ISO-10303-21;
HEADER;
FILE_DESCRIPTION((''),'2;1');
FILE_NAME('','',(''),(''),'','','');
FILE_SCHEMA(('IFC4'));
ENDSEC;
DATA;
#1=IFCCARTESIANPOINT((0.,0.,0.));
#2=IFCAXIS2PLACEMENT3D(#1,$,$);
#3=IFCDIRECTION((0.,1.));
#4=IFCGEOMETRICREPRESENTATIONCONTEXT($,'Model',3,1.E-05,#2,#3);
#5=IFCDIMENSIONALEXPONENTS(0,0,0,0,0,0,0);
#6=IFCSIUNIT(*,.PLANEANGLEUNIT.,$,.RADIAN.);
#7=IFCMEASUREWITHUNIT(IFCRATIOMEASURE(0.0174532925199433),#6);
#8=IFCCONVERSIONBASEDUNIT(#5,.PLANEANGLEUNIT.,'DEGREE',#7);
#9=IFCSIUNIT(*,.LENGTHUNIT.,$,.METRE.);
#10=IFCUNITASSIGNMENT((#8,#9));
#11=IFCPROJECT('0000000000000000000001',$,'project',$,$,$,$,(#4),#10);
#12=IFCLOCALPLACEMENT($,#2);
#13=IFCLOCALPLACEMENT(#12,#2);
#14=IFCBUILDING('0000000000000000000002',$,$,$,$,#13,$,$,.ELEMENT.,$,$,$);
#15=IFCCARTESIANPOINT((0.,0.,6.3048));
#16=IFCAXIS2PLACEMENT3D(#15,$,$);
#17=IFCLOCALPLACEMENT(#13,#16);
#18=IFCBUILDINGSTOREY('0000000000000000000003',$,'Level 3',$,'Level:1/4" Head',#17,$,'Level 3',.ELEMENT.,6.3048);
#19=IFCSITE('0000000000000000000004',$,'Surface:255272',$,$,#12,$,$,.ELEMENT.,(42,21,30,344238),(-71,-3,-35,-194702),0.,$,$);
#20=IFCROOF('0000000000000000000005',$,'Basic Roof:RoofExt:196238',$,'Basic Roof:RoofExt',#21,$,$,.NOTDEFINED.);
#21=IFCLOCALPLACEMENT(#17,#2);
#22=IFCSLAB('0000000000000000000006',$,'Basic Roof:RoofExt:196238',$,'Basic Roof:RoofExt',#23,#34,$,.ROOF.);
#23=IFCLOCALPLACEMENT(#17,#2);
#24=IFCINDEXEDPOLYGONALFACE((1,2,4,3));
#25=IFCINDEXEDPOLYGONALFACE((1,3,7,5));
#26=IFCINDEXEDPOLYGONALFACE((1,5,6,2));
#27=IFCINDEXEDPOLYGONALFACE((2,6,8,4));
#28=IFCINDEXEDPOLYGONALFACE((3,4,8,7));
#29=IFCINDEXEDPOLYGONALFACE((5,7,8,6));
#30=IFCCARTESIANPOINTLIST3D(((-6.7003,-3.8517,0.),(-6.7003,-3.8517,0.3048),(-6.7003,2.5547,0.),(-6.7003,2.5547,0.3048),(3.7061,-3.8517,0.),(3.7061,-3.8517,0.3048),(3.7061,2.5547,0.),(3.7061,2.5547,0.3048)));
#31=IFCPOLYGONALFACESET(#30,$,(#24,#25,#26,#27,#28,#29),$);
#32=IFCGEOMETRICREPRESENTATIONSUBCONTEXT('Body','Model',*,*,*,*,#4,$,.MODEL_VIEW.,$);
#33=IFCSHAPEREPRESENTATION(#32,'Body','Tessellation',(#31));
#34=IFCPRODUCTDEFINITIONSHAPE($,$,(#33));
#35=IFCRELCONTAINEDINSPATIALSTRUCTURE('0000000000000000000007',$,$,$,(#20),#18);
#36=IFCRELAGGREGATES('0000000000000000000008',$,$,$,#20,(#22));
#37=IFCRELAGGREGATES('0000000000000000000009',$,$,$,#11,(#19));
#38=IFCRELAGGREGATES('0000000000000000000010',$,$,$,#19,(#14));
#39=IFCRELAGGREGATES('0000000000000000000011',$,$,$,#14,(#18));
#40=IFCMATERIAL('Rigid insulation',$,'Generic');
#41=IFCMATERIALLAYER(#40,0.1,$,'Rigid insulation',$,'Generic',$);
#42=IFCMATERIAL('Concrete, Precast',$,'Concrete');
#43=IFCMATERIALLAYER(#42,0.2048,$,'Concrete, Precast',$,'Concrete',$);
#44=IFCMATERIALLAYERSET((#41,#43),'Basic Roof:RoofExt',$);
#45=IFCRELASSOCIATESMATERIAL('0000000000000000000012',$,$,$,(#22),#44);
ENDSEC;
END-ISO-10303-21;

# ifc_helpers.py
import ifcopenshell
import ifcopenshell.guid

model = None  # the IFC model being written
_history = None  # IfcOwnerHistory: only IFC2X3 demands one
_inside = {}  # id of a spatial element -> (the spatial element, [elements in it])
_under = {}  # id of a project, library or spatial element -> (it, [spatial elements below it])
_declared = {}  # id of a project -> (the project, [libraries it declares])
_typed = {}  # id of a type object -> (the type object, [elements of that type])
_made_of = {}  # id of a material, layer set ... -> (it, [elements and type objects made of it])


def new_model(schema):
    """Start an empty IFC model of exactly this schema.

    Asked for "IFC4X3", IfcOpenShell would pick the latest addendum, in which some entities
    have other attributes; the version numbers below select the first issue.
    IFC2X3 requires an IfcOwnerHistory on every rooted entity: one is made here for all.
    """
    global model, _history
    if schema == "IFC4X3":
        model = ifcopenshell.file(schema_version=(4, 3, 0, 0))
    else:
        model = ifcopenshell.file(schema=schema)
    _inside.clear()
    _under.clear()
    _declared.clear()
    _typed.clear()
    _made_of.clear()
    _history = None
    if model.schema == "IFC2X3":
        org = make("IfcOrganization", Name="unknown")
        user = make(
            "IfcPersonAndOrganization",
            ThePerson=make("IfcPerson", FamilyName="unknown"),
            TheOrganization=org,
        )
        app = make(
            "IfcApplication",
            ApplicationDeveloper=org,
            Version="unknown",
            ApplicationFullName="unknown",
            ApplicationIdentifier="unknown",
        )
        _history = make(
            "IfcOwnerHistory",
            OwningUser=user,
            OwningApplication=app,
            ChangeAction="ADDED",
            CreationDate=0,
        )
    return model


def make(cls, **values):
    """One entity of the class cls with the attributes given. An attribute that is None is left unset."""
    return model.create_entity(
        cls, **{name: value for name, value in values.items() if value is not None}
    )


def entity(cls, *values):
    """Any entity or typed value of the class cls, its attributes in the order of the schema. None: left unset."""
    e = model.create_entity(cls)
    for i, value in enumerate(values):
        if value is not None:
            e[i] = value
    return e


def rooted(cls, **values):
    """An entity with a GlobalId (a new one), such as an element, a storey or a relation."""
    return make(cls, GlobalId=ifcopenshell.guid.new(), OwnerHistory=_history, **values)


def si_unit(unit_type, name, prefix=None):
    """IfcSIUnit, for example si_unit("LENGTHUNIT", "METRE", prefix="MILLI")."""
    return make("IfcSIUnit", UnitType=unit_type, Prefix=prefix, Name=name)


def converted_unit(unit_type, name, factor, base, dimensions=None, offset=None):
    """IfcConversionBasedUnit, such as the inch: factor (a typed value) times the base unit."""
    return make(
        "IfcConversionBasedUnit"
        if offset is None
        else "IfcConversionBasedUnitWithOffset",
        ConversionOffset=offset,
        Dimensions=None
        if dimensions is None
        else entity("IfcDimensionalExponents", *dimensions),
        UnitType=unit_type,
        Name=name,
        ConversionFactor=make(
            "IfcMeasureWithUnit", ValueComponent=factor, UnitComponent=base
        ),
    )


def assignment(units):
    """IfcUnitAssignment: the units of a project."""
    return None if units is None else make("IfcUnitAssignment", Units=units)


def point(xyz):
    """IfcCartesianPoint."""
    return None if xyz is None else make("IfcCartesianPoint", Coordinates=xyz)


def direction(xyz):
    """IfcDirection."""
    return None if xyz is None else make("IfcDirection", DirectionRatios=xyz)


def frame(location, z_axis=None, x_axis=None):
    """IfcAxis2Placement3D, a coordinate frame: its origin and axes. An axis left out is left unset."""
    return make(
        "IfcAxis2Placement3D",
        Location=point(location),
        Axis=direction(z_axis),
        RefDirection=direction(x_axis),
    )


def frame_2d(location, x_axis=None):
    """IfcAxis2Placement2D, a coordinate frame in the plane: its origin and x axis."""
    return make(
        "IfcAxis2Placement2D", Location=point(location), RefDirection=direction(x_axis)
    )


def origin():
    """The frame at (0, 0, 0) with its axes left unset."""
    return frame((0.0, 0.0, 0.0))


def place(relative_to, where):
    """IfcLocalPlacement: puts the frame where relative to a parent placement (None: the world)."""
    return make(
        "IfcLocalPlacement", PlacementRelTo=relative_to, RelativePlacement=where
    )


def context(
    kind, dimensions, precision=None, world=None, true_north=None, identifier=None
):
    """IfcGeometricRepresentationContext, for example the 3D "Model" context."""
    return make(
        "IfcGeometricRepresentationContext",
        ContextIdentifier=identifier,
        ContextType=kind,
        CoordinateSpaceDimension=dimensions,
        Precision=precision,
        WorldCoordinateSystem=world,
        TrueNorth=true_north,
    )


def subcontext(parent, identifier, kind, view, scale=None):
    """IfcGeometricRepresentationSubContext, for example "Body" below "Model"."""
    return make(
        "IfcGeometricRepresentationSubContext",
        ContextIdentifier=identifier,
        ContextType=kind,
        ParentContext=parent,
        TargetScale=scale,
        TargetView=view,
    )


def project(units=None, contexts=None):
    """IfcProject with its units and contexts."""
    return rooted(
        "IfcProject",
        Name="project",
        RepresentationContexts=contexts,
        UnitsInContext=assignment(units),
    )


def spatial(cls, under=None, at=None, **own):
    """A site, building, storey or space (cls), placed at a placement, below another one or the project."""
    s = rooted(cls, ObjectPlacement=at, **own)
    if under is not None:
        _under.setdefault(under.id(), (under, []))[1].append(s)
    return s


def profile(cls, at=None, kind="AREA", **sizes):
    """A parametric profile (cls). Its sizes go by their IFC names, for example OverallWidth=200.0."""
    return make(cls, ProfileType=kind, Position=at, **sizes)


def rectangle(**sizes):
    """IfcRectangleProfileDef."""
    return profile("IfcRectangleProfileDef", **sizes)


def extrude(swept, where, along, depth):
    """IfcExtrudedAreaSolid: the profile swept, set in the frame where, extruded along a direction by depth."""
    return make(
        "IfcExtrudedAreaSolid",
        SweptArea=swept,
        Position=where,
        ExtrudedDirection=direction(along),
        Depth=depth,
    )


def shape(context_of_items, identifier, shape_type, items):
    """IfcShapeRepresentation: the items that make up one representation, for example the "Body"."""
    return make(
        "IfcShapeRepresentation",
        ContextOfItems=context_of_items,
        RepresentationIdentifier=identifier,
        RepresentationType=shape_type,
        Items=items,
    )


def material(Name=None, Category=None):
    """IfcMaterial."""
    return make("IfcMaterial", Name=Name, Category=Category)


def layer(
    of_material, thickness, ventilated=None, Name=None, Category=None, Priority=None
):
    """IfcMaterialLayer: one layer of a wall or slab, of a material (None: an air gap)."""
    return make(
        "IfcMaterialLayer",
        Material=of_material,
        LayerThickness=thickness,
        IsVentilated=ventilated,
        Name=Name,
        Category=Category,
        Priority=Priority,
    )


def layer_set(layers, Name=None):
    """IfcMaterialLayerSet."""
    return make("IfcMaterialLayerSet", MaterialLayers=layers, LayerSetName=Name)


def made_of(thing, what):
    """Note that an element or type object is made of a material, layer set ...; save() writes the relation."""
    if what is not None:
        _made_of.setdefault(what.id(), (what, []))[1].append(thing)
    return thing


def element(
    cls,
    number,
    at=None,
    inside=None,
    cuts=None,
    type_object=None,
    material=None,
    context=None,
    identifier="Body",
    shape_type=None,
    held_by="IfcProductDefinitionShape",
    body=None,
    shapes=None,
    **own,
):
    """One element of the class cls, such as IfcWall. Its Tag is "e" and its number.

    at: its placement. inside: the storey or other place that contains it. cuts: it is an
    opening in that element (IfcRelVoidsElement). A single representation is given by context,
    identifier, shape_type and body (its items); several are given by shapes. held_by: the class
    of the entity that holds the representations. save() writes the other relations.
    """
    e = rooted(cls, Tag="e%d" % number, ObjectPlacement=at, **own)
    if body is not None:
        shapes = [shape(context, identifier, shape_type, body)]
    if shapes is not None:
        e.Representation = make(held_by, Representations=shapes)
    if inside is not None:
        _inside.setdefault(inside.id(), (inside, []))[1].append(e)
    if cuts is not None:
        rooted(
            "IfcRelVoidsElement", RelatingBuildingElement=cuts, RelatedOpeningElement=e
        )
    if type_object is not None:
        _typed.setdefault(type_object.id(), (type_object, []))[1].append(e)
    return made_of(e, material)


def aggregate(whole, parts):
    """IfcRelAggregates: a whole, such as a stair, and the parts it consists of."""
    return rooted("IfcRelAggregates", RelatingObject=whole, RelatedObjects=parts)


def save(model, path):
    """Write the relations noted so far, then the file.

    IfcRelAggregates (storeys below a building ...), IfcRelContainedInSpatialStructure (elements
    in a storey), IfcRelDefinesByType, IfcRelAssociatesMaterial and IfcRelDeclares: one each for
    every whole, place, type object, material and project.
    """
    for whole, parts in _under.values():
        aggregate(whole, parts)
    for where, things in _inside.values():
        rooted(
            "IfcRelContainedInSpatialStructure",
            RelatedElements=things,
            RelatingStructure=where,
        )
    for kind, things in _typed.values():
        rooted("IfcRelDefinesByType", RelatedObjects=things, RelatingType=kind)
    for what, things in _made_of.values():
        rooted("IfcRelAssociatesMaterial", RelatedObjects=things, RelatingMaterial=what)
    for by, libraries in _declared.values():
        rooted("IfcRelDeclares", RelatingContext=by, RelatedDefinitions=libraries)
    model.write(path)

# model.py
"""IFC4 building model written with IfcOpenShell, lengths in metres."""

from ifc_helpers import new_model, entity, si_unit, converted_unit, direction, frame, frame_2d, origin, place, context, subcontext, project, spatial, rectangle, extrude, material, layer, layer_set, element, aggregate, save


model = new_model("IFC4")

# Units and contexts
model_context = context("Model", 3, precision=1e-05, world=origin(), true_north=direction((0.0, 1.0)))
body_context = subcontext(model_context, "Body", "Model", "MODEL_VIEW")
ifc_project = project(units=[converted_unit("PLANEANGLEUNIT", "DEGREE", entity("IfcRatioMeasure", 0.0174532925199433), si_unit("PLANEANGLEUNIT", "RADIAN"), dimensions=[0, 0, 0, 0, 0, 0, 0]), si_unit("LENGTHUNIT", "METRE")], contexts=[model_context])

# Site, building, storey
site_placement = place(None, origin())
site = spatial("IfcSite", under=ifc_project, at=site_placement, Name="Surface:255272", CompositionType="ELEMENT", RefLatitude=(42, 21, 30, 344238), RefLongitude=(-71, -3, -35, -194702), RefElevation=0.0)
building_placement = place(site_placement, origin())
building = spatial("IfcBuilding", under=site, at=building_placement, CompositionType="ELEMENT")
storey_placement = place(building_placement, frame((0.0, 0.0, 6.3048)))
storey = spatial("IfcBuildingStorey", under=building, at=storey_placement, Name="Level 3", ObjectType="Level:1/4\" Head", LongName="Level 3", CompositionType="ELEMENT", Elevation=6.3048)

# Roof, slab
roof_placement = place(storey_placement, frame((-6.7003, -3.8517, 0.0)))
roof = element("IfcRoof", 1, at=roof_placement, inside=storey, Name="Basic Roof:RoofExt:196238", ObjectType="Basic Roof:RoofExt", PredefinedType="NOTDEFINED")
ifc_material_1 = material(Name="Rigid insulation", Category="Generic")
ifc_layer_1 = layer(ifc_material_1, 0.1, Name="Rigid insulation", Category="Generic")
ifc_material_2 = material(Name="Concrete, Precast", Category="Concrete")
ifc_layer_2 = layer(ifc_material_2, 0.2048, Name="Concrete, Precast", Category="Concrete")
ifc_layer_set = layer_set([ifc_layer_1, ifc_layer_2], Name="Basic Roof:RoofExt")
slab_placement = place(roof_placement, origin())
slab = element("IfcSlab", 2, at=slab_placement, material=ifc_layer_set, Name="Basic Roof:RoofExt:196238", ObjectType="Basic Roof:RoofExt", PredefinedType="ROOF", context=body_context, shape_type="SweptSolid", body=[
    extrude(rectangle(XDim=10.4064, YDim=6.4064, at=frame_2d((0.0, 0.0), x_axis=(-1.0, 0.000007))), frame((5.2032, 3.2032, 0.0)), (0.0, 0.0, 1.0), 0.3048),
])
aggregate(roof, [slab])

save(model, "model.ifc")
